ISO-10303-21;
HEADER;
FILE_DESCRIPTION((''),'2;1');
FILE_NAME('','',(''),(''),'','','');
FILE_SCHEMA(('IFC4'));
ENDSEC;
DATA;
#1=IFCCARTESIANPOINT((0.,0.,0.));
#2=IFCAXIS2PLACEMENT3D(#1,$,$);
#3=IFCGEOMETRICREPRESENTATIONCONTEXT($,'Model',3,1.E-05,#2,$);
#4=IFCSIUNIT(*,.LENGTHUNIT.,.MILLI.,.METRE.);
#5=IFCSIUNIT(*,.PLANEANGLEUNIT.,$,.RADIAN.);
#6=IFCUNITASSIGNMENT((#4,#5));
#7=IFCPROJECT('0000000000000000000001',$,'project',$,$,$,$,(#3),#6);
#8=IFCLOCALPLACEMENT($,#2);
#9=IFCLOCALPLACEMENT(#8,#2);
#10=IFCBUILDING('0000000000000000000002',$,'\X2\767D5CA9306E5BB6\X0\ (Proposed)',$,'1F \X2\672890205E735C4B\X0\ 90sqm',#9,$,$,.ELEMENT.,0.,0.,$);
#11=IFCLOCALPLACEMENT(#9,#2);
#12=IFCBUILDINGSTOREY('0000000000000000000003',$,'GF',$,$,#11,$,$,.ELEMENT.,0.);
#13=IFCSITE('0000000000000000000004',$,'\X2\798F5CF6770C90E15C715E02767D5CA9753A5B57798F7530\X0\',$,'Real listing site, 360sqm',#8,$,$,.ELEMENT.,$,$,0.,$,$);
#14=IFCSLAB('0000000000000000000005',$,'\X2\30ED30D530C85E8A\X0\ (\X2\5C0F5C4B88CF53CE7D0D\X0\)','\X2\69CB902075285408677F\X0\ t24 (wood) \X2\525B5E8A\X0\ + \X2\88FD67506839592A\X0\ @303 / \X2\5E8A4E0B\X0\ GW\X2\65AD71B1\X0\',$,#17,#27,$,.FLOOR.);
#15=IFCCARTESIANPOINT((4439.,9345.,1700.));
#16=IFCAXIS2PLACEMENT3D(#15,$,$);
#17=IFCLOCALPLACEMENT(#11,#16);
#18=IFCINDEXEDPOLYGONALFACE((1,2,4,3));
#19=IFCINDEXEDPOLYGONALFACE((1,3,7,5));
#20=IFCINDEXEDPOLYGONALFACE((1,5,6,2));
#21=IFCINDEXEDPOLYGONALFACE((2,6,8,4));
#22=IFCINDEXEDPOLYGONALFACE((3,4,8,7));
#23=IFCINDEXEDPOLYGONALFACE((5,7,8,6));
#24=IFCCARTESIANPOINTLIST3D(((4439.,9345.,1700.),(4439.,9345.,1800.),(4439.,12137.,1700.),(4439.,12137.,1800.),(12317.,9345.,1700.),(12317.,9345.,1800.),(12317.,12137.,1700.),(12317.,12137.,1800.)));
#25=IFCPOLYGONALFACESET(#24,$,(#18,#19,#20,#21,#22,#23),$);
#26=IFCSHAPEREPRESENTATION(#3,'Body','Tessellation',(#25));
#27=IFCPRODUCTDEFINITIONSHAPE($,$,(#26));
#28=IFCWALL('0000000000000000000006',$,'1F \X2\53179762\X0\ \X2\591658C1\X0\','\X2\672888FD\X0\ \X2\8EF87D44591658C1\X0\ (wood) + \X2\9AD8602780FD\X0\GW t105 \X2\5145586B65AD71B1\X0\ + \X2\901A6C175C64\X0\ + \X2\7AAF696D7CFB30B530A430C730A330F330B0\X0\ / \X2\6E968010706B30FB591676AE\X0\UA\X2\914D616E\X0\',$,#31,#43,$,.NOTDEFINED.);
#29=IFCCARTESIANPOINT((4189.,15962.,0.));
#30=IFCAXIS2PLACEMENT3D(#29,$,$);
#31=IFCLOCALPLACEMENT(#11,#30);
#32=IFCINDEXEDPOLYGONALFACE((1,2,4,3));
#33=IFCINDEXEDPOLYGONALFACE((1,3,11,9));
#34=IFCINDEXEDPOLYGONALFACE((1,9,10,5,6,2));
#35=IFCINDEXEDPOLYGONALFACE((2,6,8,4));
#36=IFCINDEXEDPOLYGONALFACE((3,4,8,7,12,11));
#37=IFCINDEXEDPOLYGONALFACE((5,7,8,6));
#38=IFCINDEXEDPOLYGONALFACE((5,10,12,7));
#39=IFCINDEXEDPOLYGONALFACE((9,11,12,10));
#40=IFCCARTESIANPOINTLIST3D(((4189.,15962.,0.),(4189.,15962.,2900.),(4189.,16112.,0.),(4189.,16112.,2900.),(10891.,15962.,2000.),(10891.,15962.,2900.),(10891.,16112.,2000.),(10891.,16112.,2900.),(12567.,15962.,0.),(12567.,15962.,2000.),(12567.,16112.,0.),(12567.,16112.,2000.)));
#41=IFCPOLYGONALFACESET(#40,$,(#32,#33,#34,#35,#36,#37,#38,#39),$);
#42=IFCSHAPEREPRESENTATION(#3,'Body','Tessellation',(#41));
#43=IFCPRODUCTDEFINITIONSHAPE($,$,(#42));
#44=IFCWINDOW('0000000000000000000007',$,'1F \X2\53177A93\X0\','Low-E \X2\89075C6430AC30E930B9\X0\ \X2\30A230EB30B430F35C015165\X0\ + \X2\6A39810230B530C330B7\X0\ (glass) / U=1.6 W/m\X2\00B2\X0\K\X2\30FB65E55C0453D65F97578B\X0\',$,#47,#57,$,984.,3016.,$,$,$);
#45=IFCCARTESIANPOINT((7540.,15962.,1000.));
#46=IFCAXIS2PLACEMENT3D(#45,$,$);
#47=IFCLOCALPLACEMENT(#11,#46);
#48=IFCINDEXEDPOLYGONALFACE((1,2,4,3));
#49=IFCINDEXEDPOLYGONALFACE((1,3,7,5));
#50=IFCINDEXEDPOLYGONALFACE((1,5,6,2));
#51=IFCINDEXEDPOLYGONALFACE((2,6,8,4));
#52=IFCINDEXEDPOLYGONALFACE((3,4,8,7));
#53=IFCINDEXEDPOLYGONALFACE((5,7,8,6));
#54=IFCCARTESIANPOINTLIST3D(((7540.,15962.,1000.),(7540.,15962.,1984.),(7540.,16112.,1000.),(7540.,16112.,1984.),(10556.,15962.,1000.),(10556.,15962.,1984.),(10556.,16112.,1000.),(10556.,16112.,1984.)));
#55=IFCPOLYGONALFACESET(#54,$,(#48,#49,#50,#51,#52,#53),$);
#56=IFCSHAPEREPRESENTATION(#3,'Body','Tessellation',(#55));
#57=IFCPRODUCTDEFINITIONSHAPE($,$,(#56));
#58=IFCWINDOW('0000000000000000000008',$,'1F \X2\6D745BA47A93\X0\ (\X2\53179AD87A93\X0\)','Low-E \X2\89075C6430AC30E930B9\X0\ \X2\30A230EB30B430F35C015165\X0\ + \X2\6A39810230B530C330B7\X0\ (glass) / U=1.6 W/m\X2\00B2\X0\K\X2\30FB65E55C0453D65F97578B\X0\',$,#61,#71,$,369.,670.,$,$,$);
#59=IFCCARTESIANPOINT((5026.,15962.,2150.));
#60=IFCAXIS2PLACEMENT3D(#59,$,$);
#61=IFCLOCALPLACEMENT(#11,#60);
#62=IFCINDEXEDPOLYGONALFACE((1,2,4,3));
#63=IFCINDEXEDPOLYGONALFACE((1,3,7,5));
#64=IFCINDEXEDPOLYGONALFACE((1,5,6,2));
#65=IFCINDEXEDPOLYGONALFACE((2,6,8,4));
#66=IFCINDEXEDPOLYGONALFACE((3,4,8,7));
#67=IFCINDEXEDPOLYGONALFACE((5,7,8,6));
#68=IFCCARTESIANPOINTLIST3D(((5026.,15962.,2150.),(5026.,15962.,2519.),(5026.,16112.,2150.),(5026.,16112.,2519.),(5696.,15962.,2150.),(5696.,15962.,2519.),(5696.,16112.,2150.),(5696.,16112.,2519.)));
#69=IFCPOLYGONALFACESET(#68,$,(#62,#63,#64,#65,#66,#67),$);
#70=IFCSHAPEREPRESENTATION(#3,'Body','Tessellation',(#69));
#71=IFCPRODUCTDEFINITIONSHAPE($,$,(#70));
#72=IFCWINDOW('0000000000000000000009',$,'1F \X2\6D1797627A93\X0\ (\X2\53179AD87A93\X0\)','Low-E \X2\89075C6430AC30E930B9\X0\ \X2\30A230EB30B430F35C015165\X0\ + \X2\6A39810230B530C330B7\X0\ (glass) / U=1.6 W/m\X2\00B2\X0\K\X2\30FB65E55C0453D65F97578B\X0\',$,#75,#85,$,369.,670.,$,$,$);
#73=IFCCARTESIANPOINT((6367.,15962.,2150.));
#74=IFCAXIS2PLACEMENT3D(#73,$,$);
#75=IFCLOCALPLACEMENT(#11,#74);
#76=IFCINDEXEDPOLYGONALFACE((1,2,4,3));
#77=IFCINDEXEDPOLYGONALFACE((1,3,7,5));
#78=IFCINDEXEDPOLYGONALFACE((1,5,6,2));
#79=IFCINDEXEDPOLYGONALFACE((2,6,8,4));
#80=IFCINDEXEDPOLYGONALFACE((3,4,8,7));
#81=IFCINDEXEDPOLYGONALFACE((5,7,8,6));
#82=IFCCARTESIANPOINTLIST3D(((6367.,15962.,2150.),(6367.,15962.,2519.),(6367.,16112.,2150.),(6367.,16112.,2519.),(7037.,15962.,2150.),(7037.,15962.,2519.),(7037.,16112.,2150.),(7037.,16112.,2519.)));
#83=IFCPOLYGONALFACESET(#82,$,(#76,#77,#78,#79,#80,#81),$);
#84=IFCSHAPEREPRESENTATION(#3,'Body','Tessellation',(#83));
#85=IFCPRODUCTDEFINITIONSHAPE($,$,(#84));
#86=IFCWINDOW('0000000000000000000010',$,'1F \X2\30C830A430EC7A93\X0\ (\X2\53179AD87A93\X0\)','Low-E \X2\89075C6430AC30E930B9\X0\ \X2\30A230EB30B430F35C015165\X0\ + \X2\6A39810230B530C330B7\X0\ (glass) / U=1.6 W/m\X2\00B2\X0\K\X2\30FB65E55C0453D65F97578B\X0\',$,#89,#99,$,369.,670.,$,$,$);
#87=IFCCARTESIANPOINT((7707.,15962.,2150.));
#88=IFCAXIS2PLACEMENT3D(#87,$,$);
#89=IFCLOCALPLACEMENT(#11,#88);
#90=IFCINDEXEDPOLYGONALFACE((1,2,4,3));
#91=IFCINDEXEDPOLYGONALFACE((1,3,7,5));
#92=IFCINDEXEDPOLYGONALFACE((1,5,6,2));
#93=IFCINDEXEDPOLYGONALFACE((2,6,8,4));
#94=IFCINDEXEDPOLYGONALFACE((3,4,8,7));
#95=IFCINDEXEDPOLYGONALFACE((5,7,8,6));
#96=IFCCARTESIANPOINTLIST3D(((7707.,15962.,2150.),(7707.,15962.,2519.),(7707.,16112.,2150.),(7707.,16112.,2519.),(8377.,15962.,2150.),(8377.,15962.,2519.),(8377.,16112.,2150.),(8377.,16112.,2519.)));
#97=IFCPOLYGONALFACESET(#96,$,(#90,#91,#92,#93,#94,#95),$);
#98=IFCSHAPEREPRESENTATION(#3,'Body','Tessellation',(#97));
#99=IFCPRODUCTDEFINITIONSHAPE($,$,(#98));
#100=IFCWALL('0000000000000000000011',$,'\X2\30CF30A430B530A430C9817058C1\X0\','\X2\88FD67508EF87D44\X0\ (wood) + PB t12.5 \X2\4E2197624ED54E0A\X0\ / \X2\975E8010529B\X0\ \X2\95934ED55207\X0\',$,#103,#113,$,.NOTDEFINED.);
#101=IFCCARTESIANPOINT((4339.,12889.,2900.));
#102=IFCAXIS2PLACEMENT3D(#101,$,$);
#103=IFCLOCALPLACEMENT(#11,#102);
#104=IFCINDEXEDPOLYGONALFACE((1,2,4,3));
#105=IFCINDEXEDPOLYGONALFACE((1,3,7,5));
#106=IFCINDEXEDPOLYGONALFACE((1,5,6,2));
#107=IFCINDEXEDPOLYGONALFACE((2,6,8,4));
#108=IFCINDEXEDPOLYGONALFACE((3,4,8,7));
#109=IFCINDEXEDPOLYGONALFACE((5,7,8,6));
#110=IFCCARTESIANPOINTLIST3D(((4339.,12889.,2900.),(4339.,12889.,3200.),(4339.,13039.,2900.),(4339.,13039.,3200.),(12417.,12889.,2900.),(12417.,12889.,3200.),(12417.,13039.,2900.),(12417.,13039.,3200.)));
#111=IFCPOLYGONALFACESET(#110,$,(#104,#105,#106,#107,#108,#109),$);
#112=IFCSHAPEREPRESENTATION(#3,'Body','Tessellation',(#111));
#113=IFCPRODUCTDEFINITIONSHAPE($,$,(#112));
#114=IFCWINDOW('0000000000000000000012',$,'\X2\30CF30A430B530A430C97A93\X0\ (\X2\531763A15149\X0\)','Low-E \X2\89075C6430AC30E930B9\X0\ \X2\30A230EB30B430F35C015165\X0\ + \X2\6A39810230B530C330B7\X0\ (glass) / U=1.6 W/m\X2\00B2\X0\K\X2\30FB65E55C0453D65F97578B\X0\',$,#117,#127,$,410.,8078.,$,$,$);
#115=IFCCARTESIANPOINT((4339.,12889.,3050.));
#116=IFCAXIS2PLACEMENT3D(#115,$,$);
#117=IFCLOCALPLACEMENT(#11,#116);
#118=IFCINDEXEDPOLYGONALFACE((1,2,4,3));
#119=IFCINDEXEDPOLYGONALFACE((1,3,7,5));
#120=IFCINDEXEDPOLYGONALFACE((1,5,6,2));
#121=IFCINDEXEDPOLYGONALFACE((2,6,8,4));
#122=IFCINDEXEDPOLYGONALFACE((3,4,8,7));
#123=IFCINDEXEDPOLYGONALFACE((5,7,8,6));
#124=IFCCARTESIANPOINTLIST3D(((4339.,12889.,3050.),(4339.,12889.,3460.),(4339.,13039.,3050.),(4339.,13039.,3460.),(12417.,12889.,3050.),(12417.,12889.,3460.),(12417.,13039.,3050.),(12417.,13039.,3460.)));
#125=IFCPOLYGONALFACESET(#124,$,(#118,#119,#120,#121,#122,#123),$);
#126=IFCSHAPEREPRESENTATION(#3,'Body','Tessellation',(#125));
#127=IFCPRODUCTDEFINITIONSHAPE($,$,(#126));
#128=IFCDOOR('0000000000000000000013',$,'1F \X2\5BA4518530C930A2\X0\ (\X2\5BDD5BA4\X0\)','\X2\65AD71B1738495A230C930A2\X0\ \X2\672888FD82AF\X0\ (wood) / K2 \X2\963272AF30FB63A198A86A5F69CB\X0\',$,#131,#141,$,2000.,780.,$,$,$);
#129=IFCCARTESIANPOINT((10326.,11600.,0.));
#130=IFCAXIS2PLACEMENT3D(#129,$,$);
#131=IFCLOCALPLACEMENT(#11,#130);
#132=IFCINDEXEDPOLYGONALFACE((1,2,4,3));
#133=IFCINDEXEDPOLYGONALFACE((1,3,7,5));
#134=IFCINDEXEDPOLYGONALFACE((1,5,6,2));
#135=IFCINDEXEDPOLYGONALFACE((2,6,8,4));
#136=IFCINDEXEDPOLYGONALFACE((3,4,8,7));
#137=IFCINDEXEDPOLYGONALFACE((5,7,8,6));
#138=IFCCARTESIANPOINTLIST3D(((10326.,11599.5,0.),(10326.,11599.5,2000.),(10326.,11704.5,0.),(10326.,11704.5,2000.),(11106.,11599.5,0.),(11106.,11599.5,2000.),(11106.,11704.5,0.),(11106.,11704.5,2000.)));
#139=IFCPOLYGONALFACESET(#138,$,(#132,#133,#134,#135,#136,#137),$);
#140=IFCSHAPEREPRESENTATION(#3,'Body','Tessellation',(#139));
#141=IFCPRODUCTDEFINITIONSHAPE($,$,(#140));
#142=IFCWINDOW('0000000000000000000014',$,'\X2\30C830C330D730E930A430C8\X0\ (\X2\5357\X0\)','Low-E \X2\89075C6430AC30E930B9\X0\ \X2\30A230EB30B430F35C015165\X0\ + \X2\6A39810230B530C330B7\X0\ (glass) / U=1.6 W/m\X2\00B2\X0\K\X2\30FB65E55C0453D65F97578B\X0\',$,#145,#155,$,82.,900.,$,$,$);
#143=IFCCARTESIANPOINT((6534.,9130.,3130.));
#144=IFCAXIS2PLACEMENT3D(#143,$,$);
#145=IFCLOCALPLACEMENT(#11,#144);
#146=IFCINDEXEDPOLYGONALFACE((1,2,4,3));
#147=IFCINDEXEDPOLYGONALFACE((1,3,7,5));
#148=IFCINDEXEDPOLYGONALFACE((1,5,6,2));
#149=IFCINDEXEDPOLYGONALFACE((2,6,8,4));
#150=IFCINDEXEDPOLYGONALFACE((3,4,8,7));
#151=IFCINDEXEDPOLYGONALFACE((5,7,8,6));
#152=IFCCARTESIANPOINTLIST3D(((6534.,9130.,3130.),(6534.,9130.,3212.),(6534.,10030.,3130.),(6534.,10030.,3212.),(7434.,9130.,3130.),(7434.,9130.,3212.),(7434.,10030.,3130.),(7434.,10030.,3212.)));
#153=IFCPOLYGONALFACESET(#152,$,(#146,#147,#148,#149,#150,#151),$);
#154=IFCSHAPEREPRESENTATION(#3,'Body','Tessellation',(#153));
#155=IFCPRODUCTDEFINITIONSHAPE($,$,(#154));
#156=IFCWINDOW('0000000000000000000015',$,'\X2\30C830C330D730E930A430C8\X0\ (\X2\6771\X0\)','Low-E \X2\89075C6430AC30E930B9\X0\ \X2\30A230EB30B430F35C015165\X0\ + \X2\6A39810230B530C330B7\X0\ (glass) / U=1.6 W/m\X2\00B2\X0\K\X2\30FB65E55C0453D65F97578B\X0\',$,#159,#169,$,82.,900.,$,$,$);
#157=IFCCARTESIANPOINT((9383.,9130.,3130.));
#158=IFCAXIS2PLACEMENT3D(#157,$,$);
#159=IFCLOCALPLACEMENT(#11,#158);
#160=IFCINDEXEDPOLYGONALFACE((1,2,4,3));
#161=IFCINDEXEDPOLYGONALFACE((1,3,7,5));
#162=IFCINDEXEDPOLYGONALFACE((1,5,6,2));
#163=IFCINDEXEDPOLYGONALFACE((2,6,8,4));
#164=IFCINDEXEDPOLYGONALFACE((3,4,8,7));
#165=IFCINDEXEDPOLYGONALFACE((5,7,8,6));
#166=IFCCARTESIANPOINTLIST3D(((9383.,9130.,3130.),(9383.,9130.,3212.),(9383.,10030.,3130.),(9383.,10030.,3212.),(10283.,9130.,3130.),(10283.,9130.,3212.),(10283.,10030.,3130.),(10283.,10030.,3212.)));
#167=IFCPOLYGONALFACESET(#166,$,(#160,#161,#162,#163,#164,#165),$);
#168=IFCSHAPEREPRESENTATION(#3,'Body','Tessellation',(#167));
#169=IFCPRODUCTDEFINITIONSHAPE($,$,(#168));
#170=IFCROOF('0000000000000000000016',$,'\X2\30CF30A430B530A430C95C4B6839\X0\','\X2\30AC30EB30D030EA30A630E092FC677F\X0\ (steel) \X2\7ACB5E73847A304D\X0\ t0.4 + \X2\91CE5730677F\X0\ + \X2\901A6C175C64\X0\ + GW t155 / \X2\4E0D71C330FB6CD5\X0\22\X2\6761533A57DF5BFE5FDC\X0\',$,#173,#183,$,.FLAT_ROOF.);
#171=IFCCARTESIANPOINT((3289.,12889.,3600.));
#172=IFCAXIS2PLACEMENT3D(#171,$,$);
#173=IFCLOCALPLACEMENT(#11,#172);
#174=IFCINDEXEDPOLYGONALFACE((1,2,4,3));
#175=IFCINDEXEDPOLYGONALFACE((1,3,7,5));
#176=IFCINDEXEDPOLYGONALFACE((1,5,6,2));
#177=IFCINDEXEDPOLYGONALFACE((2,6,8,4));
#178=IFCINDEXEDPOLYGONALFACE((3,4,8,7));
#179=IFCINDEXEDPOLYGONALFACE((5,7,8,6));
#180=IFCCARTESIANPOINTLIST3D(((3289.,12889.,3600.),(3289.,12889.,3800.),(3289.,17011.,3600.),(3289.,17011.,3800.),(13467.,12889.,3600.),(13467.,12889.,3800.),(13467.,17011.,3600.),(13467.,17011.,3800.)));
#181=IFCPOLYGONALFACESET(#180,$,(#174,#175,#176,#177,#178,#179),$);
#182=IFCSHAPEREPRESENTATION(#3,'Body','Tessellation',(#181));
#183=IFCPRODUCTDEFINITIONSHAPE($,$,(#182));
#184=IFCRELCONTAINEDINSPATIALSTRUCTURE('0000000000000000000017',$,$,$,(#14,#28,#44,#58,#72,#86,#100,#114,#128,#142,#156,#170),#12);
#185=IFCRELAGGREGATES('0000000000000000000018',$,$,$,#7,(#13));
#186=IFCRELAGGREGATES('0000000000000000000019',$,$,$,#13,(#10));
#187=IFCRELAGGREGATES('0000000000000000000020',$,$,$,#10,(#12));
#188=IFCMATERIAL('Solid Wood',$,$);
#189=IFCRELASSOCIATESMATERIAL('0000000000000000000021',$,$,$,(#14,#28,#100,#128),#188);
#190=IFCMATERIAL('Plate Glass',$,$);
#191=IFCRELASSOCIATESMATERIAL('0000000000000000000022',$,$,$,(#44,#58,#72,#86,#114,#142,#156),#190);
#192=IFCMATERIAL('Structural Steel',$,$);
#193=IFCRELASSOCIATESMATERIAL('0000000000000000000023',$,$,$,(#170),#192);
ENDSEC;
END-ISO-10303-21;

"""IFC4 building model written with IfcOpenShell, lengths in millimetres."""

from ifc_helpers import new_model, si_unit, frame, frame_2d, origin, place, context, project, spatial, rectangle, extrude, material, element, fill, save


model = new_model("IFC4")

# Units and contexts
model_context = context("Model", 3, precision=1e-05, world=origin())
ifc_project = project(units=[si_unit("LENGTHUNIT", "METRE", prefix="MILLI"), si_unit("PLANEANGLEUNIT", "RADIAN")], contexts=[model_context])

# Site, building, storey
site_placement = place(None, origin())
site = spatial("IfcSite", under=ifc_project, at=site_placement, Name="福島県郡山市白岩町字福田", ObjectType="Real listing site, 360sqm", CompositionType="ELEMENT", RefElevation=0.0)
building_placement = place(site_placement, origin())
building = spatial("IfcBuilding", under=site, at=building_placement, Name="白岩の家 (Proposed)", ObjectType="1F 木造平屋 90sqm", CompositionType="ELEMENT", ElevationOfRefHeight=0.0, ElevationOfTerrain=0.0)
storey_placement = place(building_placement, origin())
storey = spatial("IfcBuildingStorey", under=building, at=storey_placement, Name="GF", CompositionType="ELEMENT", Elevation=0.0)

# Slab
ifc_material_1 = material(Name="Solid Wood")
slab_placement = place(storey_placement, frame((4439.0, 9345.0, 1700.0)))
element("IfcSlab", 1, at=slab_placement, inside=storey, material=ifc_material_1, Name="ロフト床 (小屋裏収納)", Description="構造用合板 t24 (wood) 剛床 + 製材根太 @303 / 床下 GW断熱", PredefinedType="FLOOR", context=model_context, shape_type="SweptSolid", body=[
    extrude(rectangle(XDim=7878.0, YDim=2792.0, at=frame_2d((3939.0, 1396.0))), frame((4439.0, 9345.0, 1700.0)), (0.0, 0.0, 1.0), 100.0),
])

# Wall, openings, windows
wall_1_placement = place(storey_placement, frame((4189.0, 15962.0, 0.0)))
wall_1 = element("IfcWall", 2, at=wall_1_placement, inside=storey, material=ifc_material_1, Name="1F 北面 外壁", Description="木製 軸組外壁 (wood) + 高性能GW t105 充填断熱 + 通気層 + 窯業系サイディング / 準耐火・外皮UA配慮", PredefinedType="NOTDEFINED", context=model_context, shape_type="SweptSolid", body=[
    extrude(rectangle(XDim=8378.0, YDim=150.0, at=frame_2d((4189.0, 75.0))), frame((4189.0, 15962.0, 0.0)), (0.0, 0.0, 1.0), 2900.0),
])
opening_1_placement = place(storey_placement, frame((7540.0, 15962.0, 1000.0)))
opening_1 = element("IfcOpeningElement", 3, at=opening_1_placement, cuts=wall_1, PredefinedType="NOTDEFINED", context=model_context, shape_type="SweptSolid", body=[
    extrude(rectangle(XDim=3016.0, YDim=150.0, at=frame_2d((1508.0, 75.0))), frame((7540.0, 15962.0, 1000.0)), (0.0, 0.0, 1.0), 984.0),
])
opening_2_placement = place(storey_placement, frame((5026.0, 15962.0, 2150.0)))
opening_2 = element("IfcOpeningElement", 4, at=opening_2_placement, cuts=wall_1, PredefinedType="NOTDEFINED", context=model_context, shape_type="SweptSolid", body=[
    extrude(rectangle(XDim=670.0, YDim=150.0, at=frame_2d((335.0, 75.0))), frame((5026.0, 15962.0, 2150.0)), (0.0, 0.0, 1.0), 369.0),
])
opening_3_placement = place(storey_placement, frame((6367.0, 15962.0, 2150.0)))
opening_3 = element("IfcOpeningElement", 5, at=opening_3_placement, cuts=wall_1, PredefinedType="NOTDEFINED", context=model_context, shape_type="SweptSolid", body=[
    extrude(rectangle(XDim=670.0, YDim=150.0, at=frame_2d((335.0, 75.0))), frame((6367.0, 15962.0, 2150.0)), (0.0, 0.0, 1.0), 369.0),
])
opening_4_placement = place(storey_placement, frame((7707.0, 15962.0, 2150.0)))
opening_4 = element("IfcOpeningElement", 6, at=opening_4_placement, cuts=wall_1, PredefinedType="NOTDEFINED", context=model_context, shape_type="SweptSolid", body=[
    extrude(rectangle(XDim=670.0, YDim=150.0, at=frame_2d((335.0, 75.0))), frame((7707.0, 15962.0, 2150.0)), (0.0, 0.0, 1.0), 369.0),
])
ifc_material_2 = material(Name="Plate Glass")
window_1_placement = place(storey_placement, frame((7540.0, 15962.0, 1000.0)))
window_1 = element("IfcWindow", 7, at=window_1_placement, inside=storey, material=ifc_material_2, Name="1F 北窓", Description="Low-E 複層ガラス アルゴン封入 + 樹脂サッシ (glass) / U=1.6 W/m²K・日射取得型", OverallHeight=984.0, OverallWidth=3016.0, context=model_context, shape_type="SweptSolid", body=[
    extrude(rectangle(XDim=3016.0, YDim=150.0, at=frame_2d((1508.0, 75.0))), frame((7540.0, 15962.0, 1000.0)), (0.0, 0.0, 1.0), 984.0),
])
fill(opening_1, window_1)
window_2_placement = place(storey_placement, frame((5026.0, 15962.0, 2150.0)))
window_2 = element("IfcWindow", 8, at=window_2_placement, inside=storey, material=ifc_material_2, Name="1F 浴室窓 (北高窓)", Description="Low-E 複層ガラス アルゴン封入 + 樹脂サッシ (glass) / U=1.6 W/m²K・日射取得型", OverallHeight=369.0, OverallWidth=670.0, context=model_context, shape_type="SweptSolid", body=[
    extrude(rectangle(XDim=670.0, YDim=150.0, at=frame_2d((335.0, 75.0))), frame((5026.0, 15962.0, 2150.0)), (0.0, 0.0, 1.0), 369.0),
])
fill(opening_2, window_2)
window_3_placement = place(storey_placement, frame((6367.0, 15962.0, 2150.0)))
window_3 = element("IfcWindow", 9, at=window_3_placement, inside=storey, material=ifc_material_2, Name="1F 洗面窓 (北高窓)", Description="Low-E 複層ガラス アルゴン封入 + 樹脂サッシ (glass) / U=1.6 W/m²K・日射取得型", OverallHeight=369.0, OverallWidth=670.0, context=model_context, shape_type="SweptSolid", body=[
    extrude(rectangle(XDim=670.0, YDim=150.0, at=frame_2d((335.0, 75.0))), frame((6367.0, 15962.0, 2150.0)), (0.0, 0.0, 1.0), 369.0),
])
fill(opening_3, window_3)
window_4_placement = place(storey_placement, frame((7707.0, 15962.0, 2150.0)))
window_4 = element("IfcWindow", 10, at=window_4_placement, inside=storey, material=ifc_material_2, Name="1F トイレ窓 (北高窓)", Description="Low-E 複層ガラス アルゴン封入 + 樹脂サッシ (glass) / U=1.6 W/m²K・日射取得型", OverallHeight=369.0, OverallWidth=670.0, context=model_context, shape_type="SweptSolid", body=[
    extrude(rectangle(XDim=670.0, YDim=150.0, at=frame_2d((335.0, 75.0))), frame((7707.0, 15962.0, 2150.0)), (0.0, 0.0, 1.0), 369.0),
])
fill(opening_4, window_4)

# Wall, opening, window
wall_2_placement = place(storey_placement, frame((4339.0, 12889.0, 2900.0)))
wall_2 = element("IfcWall", 11, at=wall_2_placement, inside=storey, material=ifc_material_1, Name="ハイサイド腰壁", Description="製材軸組 (wood) + PB t12.5 両面仕上 / 非耐力 間仕切", PredefinedType="NOTDEFINED", context=model_context, shape_type="SweptSolid", body=[
    extrude(rectangle(XDim=8078.0, YDim=150.0, at=frame_2d((4039.0, 75.0))), frame((4339.0, 12889.0, 2900.0)), (0.0, 0.0, 1.0), 700.0),
])
opening_5_placement = place(storey_placement, frame((4339.0, 12889.0, 3050.0)))
opening_5 = element("IfcOpeningElement", 12, at=opening_5_placement, cuts=wall_2, PredefinedType="NOTDEFINED", context=model_context, shape_type="SweptSolid", body=[
    extrude(rectangle(XDim=8078.0, YDim=150.0, at=frame_2d((4039.0, 75.0))), frame((4339.0, 12889.0, 3050.0)), (0.0, 0.0, 1.0), 410.0),
])
window_5_placement = place(storey_placement, frame((4339.0, 12889.0, 3050.0)))
window_5 = element("IfcWindow", 13, at=window_5_placement, inside=storey, material=ifc_material_2, Name="ハイサイド窓 (北採光)", Description="Low-E 複層ガラス アルゴン封入 + 樹脂サッシ (glass) / U=1.6 W/m²K・日射取得型", OverallHeight=410.0, OverallWidth=8078.0, context=model_context, shape_type="SweptSolid", body=[
    extrude(rectangle(XDim=8078.0, YDim=150.0, at=frame_2d((4039.0, 75.0))), frame((4339.0, 12889.0, 3050.0)), (0.0, 0.0, 1.0), 410.0),
])
fill(opening_5, window_5)

# Door
door_1_placement = place(storey_placement, frame((10326.0, 11600.0, 0.0)))
element("IfcDoor", 14, at=door_1_placement, inside=storey, material=ifc_material_1, Name="1F 室内ドア (寝室)", Description="断熱玄関ドア 木製芯 (wood) / K2 防犯・採風機構", OverallHeight=2000.0, OverallWidth=780.0, context=model_context, shape_type="SweptSolid", body=[
    extrude(rectangle(XDim=780.0, YDim=105.0, at=frame_2d((390.0, 52.0))), frame((10326.0, 11600.0, 0.0)), (0.0, 0.0, 1.0), 2000.0),
])

# Windows
window_6_placement = place(storey_placement, frame((6534.0, 9130.0, 3130.0)))
element("IfcWindow", 15, at=window_6_placement, inside=storey, material=ifc_material_2, Name="トップライト (南)", Description="Low-E 複層ガラス アルゴン封入 + 樹脂サッシ (glass) / U=1.6 W/m²K・日射取得型", OverallHeight=82.0, OverallWidth=900.0, context=model_context, shape_type="SweptSolid", body=[
    extrude(rectangle(XDim=900.0, YDim=900.0, at=frame_2d((450.0, 450.0))), frame((6534.0, 9130.0, 3130.0)), (0.0, 0.0, 1.0), 82.0),
])
window_7_placement = place(storey_placement, frame((9383.0, 9130.0, 3130.0)))
element("IfcWindow", 16, at=window_7_placement, inside=storey, material=ifc_material_2, Name="トップライト (東)", Description="Low-E 複層ガラス アルゴン封入 + 樹脂サッシ (glass) / U=1.6 W/m²K・日射取得型", OverallHeight=82.0, OverallWidth=900.0, context=model_context, shape_type="SweptSolid", body=[
    extrude(rectangle(XDim=900.0, YDim=900.0, at=frame_2d((450.0, 450.0))), frame((9383.0, 9130.0, 3130.0)), (0.0, 0.0, 1.0), 82.0),
])

# Roof
ifc_material_3 = material(Name="Structural Steel")
roof_placement = place(storey_placement, frame((3289.0, 12889.0, 3600.0)))
element("IfcRoof", 17, at=roof_placement, inside=storey, material=ifc_material_3, Name="ハイサイド屋根", Description="ガルバリウム鋼板 (steel) 立平葺き t0.4 + 野地板 + 通気層 + GW t155 / 不燃・法22条区域対応", PredefinedType="FLAT_ROOF", context=model_context, shape_type="SweptSolid", body=[
    extrude(rectangle(XDim=10178.0, YDim=4122.0, at=frame_2d((5089.0, 2061.0))), frame((3289.0, 12889.0, 3600.0)), (0.0, 0.0, 1.0), 200.0),
])

save(model, "model.ifc")
